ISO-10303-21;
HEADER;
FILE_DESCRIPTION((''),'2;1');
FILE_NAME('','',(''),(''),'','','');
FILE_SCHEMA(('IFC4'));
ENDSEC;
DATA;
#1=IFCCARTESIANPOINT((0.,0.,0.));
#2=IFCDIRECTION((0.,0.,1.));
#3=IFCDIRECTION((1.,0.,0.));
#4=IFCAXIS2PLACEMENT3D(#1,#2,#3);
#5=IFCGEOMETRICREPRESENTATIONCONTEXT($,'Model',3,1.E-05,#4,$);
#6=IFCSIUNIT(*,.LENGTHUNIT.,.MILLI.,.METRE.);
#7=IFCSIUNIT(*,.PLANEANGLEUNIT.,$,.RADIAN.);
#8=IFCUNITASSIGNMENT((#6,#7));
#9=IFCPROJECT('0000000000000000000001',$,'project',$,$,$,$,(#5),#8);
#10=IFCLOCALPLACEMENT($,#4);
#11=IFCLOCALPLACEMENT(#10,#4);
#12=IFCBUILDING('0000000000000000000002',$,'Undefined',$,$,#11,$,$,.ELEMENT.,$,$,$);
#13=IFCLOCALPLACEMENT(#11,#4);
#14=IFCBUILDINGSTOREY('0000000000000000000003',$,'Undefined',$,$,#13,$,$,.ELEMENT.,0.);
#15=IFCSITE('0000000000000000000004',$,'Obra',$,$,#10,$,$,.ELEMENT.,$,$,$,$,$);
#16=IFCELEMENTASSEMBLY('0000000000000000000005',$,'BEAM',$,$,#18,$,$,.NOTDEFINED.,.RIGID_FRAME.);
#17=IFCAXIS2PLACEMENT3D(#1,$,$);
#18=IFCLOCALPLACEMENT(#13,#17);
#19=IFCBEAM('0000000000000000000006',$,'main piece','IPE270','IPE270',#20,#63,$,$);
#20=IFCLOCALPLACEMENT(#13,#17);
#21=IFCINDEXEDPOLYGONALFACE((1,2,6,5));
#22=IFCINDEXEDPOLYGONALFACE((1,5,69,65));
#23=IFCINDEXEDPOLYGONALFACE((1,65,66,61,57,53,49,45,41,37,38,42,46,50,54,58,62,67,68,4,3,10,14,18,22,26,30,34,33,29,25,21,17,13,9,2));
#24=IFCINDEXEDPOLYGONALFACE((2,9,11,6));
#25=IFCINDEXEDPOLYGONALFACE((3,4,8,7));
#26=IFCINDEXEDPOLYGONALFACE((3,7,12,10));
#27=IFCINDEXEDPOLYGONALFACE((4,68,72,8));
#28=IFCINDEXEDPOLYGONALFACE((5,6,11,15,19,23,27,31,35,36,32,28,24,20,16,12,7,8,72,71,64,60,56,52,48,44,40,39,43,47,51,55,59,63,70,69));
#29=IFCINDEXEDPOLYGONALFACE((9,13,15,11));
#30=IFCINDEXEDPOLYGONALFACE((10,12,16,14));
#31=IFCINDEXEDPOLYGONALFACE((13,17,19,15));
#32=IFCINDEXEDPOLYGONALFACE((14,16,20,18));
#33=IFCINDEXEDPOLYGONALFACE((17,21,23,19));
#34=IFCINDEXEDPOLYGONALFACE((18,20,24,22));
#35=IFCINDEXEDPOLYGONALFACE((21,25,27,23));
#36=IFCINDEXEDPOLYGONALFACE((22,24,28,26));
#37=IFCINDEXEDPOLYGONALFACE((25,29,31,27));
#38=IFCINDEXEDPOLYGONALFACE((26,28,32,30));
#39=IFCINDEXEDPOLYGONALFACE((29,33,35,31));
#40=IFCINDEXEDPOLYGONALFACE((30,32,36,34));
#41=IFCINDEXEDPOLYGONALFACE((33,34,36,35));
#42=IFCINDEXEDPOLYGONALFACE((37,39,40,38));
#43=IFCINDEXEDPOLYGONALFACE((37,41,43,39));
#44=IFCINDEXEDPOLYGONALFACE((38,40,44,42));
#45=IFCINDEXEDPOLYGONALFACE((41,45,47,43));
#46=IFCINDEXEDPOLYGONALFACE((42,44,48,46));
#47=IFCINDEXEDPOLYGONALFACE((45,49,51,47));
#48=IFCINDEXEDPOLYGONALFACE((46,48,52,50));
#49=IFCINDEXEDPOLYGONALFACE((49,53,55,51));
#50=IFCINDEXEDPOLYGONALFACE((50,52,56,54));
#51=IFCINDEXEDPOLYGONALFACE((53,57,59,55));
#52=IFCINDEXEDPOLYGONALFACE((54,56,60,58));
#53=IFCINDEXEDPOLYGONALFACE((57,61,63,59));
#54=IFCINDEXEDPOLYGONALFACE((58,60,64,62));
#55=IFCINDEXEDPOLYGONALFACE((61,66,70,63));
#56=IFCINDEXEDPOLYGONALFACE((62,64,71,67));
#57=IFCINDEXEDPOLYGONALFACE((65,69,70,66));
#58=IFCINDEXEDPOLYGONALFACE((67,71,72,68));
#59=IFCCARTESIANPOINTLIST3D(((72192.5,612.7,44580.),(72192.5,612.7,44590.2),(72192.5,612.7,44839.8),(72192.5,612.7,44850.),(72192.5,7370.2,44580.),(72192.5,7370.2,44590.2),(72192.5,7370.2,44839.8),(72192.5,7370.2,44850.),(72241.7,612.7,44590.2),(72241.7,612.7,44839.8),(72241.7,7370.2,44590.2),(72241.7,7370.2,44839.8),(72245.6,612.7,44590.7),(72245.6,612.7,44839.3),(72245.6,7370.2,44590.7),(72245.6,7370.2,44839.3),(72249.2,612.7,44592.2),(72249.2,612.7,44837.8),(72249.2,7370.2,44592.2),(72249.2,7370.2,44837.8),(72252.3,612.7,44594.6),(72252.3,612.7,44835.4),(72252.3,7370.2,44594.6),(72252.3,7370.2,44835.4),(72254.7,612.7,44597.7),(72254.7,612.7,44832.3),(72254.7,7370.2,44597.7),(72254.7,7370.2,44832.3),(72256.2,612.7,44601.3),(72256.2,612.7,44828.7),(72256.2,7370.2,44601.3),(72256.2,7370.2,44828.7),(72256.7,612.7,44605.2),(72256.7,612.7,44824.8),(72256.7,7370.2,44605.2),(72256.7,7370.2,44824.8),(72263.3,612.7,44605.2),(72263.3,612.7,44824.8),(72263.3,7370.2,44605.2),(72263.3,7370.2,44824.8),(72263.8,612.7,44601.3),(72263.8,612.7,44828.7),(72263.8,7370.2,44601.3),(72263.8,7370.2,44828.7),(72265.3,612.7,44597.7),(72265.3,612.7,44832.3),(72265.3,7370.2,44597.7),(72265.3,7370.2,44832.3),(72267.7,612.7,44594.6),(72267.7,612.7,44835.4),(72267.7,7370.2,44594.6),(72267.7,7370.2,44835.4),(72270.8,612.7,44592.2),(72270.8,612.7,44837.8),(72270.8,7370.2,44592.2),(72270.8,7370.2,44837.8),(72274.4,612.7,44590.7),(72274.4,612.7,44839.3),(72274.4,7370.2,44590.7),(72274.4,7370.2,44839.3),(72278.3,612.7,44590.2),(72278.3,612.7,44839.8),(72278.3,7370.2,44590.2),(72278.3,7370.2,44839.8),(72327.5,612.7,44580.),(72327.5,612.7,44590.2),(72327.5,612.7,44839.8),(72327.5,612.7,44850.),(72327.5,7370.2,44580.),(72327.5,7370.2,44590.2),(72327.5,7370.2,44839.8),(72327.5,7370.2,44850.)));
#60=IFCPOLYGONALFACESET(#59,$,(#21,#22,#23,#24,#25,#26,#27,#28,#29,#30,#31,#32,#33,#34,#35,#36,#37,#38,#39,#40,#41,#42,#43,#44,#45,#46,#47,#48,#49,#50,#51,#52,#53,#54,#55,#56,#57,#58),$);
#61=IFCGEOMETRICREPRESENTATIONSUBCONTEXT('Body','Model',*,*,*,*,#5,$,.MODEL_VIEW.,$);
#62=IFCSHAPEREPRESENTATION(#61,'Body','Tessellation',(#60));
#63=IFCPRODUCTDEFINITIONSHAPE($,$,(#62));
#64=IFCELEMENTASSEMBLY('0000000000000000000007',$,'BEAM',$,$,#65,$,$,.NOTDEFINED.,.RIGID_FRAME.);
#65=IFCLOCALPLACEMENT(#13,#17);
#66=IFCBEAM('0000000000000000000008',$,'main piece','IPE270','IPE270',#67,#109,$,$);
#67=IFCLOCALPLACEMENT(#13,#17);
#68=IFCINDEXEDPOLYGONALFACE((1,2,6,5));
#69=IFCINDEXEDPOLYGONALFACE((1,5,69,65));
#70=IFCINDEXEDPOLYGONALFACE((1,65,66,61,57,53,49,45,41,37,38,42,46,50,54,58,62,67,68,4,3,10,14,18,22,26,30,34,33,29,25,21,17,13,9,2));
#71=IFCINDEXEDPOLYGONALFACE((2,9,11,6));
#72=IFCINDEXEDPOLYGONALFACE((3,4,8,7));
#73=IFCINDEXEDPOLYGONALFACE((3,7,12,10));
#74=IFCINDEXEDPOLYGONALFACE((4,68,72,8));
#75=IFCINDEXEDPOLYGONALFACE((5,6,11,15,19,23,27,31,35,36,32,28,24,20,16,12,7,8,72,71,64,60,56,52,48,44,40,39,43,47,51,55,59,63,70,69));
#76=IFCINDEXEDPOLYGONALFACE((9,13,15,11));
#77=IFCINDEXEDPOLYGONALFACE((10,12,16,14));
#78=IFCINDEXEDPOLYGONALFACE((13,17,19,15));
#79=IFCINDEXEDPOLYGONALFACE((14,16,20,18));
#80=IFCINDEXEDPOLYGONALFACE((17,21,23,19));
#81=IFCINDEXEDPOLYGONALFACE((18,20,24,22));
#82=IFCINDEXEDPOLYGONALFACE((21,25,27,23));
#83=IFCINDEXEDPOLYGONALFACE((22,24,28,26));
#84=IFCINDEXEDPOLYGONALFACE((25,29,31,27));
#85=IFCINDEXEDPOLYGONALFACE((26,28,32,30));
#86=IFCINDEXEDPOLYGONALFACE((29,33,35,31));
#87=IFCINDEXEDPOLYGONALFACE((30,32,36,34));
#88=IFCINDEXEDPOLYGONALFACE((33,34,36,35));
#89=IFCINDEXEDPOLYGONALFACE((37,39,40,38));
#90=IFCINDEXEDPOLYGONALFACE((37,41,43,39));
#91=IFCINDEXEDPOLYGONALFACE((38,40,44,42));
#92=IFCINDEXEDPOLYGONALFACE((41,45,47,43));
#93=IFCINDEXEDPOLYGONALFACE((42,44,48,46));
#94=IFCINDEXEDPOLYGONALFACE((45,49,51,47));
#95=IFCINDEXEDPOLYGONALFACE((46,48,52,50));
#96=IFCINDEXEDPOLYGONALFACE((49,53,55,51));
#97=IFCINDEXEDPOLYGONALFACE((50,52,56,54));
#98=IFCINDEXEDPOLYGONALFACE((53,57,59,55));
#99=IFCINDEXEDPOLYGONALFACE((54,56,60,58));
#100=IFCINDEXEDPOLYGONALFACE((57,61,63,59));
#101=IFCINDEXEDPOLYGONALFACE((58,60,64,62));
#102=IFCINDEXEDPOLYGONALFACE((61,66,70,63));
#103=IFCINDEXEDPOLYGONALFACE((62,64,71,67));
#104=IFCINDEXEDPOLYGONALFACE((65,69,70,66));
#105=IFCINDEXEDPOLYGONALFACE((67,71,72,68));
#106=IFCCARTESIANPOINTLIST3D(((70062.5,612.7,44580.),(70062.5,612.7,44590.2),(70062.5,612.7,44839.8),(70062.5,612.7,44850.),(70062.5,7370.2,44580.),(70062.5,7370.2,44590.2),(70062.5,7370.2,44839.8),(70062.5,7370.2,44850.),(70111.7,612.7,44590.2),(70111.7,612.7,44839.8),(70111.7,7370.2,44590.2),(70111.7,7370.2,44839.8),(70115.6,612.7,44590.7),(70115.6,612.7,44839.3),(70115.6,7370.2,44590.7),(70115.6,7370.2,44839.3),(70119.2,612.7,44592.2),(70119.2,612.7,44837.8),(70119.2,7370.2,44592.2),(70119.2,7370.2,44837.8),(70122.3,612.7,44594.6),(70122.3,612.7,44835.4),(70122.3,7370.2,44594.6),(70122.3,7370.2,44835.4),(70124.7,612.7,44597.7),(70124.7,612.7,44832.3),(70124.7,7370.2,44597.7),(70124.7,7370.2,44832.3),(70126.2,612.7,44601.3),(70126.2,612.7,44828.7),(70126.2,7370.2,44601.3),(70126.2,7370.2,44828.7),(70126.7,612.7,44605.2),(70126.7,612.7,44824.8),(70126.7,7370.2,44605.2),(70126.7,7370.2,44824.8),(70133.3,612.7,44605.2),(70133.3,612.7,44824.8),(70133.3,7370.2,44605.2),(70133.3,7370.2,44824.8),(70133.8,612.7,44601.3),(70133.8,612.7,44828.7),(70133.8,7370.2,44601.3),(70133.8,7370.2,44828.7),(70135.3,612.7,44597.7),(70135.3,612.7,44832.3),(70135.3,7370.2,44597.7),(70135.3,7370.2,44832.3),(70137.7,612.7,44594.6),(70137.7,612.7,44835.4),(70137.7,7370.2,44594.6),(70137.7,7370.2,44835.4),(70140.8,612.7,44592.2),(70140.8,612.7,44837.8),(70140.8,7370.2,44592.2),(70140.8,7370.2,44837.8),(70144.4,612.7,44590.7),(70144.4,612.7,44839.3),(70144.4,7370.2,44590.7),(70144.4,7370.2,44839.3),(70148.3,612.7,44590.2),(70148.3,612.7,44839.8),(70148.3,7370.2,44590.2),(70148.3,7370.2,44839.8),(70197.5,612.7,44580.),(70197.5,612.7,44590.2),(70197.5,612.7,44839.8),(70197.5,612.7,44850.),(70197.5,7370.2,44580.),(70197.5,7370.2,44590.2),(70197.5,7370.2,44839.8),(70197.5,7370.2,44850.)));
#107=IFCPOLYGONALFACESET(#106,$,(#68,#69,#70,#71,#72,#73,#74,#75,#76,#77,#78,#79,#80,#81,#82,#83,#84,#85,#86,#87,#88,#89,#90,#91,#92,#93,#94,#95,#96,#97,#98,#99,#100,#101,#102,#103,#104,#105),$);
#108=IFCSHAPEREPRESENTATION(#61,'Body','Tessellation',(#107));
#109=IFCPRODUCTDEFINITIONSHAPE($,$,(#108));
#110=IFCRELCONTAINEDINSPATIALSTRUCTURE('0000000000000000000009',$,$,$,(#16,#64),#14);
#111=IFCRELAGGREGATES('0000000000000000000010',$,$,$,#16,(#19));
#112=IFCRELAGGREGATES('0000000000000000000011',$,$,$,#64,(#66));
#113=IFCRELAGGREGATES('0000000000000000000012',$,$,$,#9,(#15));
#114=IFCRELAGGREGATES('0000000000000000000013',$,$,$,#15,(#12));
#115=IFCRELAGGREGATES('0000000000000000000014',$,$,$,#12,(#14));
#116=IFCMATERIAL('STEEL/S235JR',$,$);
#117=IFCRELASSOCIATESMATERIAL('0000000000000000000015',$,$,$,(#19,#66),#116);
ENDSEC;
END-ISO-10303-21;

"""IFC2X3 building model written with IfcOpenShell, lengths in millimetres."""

from ifc_helpers import new_model, si_unit, frame, origin_with_axes, origin_2d_with_axis, place, context, subcontext, project, spatial, i_section, extrude, material, element, aggregate, save


model = new_model("IFC2X3")

# Units and contexts
model_context = context("Model", 3, precision=1e-05, world=origin_with_axes())
body_context = subcontext(model_context, "Body", "Model", "MODEL_VIEW")
ifc_project = project(units=[si_unit("LENGTHUNIT", "METRE", prefix="MILLI"), si_unit("PLANEANGLEUNIT", "RADIAN")], contexts=[model_context])

# Site, building, storey
site_placement = place(None, origin_with_axes())
site = spatial("IfcSite", under=ifc_project, at=site_placement, Name="Obra", CompositionType="ELEMENT")
building_placement = place(site_placement, origin_with_axes())
building = spatial("IfcBuilding", under=site, at=building_placement, Name="Undefined", CompositionType="ELEMENT")
storey_placement = place(building_placement, origin_with_axes())
storey = spatial("IfcBuildingStorey", under=building, at=storey_placement, Name="Undefined", CompositionType="ELEMENT", Elevation=0.0)

# Element assemblies, beams
ifc_material_1 = material(Name="STEEL/S235JR")
assembly_1_placement = place(storey_placement, origin_with_axes())
assembly_1 = element("IfcElementAssembly", 1, at=assembly_1_placement, inside=storey, Name="BEAM", AssemblyPlace="NOTDEFINED", PredefinedType="RIGID_FRAME")
beam_1_placement = place(assembly_1_placement, frame((72260.0, 7370.2, 44715.0), z_axis=(0.0, 0.0, 1.0), x_axis=(0.0, -1.0, 0.0)))
beam_1 = element("IfcBeam", 2, at=beam_1_placement, material=ifc_material_1, Name="main piece", Description="IPE270", ObjectType="IPE270", context=body_context, shape_type="SweptSolid", body=[
    extrude(i_section(OverallWidth=135.0, OverallDepth=270.0, WebThickness=6.6, FlangeThickness=10.2, FilletRadius=15.0, at=origin_2d_with_axis()), frame((6757.5, 0.0, 0.0), z_axis=(-1.0, 0.0, 0.0), x_axis=(0.0, -1.0, 0.0)), (0.0, 0.0, 1.0), 6757.4),
])
aggregate(assembly_1, [beam_1])
assembly_2_placement = place(storey_placement, origin_with_axes())
assembly_2 = element("IfcElementAssembly", 3, at=assembly_2_placement, inside=storey, Name="BEAM", AssemblyPlace="NOTDEFINED", PredefinedType="RIGID_FRAME")
beam_2_placement = place(assembly_2_placement, frame((70130.0, 612.7, 44715.0), z_axis=(0.0, 0.0, 1.0), x_axis=(0.0, 1.0, 0.0)))
beam_2 = element("IfcBeam", 4, at=beam_2_placement, material=ifc_material_1, Name="main piece", Description="IPE270", ObjectType="IPE270", context=body_context, shape_type="SweptSolid", body=[
    extrude(i_section(OverallWidth=135.0, OverallDepth=270.0, WebThickness=6.6, FlangeThickness=10.2, FilletRadius=15.0, at=origin_2d_with_axis()), frame((6757.5, 0.0, 0.0), z_axis=(-1.0, 0.0, 0.0), x_axis=(0.0, -1.0, 0.0)), (0.0, 0.0, 1.0), 6757.5),
])
aggregate(assembly_2, [beam_2])

save(model, "model.ifc")
